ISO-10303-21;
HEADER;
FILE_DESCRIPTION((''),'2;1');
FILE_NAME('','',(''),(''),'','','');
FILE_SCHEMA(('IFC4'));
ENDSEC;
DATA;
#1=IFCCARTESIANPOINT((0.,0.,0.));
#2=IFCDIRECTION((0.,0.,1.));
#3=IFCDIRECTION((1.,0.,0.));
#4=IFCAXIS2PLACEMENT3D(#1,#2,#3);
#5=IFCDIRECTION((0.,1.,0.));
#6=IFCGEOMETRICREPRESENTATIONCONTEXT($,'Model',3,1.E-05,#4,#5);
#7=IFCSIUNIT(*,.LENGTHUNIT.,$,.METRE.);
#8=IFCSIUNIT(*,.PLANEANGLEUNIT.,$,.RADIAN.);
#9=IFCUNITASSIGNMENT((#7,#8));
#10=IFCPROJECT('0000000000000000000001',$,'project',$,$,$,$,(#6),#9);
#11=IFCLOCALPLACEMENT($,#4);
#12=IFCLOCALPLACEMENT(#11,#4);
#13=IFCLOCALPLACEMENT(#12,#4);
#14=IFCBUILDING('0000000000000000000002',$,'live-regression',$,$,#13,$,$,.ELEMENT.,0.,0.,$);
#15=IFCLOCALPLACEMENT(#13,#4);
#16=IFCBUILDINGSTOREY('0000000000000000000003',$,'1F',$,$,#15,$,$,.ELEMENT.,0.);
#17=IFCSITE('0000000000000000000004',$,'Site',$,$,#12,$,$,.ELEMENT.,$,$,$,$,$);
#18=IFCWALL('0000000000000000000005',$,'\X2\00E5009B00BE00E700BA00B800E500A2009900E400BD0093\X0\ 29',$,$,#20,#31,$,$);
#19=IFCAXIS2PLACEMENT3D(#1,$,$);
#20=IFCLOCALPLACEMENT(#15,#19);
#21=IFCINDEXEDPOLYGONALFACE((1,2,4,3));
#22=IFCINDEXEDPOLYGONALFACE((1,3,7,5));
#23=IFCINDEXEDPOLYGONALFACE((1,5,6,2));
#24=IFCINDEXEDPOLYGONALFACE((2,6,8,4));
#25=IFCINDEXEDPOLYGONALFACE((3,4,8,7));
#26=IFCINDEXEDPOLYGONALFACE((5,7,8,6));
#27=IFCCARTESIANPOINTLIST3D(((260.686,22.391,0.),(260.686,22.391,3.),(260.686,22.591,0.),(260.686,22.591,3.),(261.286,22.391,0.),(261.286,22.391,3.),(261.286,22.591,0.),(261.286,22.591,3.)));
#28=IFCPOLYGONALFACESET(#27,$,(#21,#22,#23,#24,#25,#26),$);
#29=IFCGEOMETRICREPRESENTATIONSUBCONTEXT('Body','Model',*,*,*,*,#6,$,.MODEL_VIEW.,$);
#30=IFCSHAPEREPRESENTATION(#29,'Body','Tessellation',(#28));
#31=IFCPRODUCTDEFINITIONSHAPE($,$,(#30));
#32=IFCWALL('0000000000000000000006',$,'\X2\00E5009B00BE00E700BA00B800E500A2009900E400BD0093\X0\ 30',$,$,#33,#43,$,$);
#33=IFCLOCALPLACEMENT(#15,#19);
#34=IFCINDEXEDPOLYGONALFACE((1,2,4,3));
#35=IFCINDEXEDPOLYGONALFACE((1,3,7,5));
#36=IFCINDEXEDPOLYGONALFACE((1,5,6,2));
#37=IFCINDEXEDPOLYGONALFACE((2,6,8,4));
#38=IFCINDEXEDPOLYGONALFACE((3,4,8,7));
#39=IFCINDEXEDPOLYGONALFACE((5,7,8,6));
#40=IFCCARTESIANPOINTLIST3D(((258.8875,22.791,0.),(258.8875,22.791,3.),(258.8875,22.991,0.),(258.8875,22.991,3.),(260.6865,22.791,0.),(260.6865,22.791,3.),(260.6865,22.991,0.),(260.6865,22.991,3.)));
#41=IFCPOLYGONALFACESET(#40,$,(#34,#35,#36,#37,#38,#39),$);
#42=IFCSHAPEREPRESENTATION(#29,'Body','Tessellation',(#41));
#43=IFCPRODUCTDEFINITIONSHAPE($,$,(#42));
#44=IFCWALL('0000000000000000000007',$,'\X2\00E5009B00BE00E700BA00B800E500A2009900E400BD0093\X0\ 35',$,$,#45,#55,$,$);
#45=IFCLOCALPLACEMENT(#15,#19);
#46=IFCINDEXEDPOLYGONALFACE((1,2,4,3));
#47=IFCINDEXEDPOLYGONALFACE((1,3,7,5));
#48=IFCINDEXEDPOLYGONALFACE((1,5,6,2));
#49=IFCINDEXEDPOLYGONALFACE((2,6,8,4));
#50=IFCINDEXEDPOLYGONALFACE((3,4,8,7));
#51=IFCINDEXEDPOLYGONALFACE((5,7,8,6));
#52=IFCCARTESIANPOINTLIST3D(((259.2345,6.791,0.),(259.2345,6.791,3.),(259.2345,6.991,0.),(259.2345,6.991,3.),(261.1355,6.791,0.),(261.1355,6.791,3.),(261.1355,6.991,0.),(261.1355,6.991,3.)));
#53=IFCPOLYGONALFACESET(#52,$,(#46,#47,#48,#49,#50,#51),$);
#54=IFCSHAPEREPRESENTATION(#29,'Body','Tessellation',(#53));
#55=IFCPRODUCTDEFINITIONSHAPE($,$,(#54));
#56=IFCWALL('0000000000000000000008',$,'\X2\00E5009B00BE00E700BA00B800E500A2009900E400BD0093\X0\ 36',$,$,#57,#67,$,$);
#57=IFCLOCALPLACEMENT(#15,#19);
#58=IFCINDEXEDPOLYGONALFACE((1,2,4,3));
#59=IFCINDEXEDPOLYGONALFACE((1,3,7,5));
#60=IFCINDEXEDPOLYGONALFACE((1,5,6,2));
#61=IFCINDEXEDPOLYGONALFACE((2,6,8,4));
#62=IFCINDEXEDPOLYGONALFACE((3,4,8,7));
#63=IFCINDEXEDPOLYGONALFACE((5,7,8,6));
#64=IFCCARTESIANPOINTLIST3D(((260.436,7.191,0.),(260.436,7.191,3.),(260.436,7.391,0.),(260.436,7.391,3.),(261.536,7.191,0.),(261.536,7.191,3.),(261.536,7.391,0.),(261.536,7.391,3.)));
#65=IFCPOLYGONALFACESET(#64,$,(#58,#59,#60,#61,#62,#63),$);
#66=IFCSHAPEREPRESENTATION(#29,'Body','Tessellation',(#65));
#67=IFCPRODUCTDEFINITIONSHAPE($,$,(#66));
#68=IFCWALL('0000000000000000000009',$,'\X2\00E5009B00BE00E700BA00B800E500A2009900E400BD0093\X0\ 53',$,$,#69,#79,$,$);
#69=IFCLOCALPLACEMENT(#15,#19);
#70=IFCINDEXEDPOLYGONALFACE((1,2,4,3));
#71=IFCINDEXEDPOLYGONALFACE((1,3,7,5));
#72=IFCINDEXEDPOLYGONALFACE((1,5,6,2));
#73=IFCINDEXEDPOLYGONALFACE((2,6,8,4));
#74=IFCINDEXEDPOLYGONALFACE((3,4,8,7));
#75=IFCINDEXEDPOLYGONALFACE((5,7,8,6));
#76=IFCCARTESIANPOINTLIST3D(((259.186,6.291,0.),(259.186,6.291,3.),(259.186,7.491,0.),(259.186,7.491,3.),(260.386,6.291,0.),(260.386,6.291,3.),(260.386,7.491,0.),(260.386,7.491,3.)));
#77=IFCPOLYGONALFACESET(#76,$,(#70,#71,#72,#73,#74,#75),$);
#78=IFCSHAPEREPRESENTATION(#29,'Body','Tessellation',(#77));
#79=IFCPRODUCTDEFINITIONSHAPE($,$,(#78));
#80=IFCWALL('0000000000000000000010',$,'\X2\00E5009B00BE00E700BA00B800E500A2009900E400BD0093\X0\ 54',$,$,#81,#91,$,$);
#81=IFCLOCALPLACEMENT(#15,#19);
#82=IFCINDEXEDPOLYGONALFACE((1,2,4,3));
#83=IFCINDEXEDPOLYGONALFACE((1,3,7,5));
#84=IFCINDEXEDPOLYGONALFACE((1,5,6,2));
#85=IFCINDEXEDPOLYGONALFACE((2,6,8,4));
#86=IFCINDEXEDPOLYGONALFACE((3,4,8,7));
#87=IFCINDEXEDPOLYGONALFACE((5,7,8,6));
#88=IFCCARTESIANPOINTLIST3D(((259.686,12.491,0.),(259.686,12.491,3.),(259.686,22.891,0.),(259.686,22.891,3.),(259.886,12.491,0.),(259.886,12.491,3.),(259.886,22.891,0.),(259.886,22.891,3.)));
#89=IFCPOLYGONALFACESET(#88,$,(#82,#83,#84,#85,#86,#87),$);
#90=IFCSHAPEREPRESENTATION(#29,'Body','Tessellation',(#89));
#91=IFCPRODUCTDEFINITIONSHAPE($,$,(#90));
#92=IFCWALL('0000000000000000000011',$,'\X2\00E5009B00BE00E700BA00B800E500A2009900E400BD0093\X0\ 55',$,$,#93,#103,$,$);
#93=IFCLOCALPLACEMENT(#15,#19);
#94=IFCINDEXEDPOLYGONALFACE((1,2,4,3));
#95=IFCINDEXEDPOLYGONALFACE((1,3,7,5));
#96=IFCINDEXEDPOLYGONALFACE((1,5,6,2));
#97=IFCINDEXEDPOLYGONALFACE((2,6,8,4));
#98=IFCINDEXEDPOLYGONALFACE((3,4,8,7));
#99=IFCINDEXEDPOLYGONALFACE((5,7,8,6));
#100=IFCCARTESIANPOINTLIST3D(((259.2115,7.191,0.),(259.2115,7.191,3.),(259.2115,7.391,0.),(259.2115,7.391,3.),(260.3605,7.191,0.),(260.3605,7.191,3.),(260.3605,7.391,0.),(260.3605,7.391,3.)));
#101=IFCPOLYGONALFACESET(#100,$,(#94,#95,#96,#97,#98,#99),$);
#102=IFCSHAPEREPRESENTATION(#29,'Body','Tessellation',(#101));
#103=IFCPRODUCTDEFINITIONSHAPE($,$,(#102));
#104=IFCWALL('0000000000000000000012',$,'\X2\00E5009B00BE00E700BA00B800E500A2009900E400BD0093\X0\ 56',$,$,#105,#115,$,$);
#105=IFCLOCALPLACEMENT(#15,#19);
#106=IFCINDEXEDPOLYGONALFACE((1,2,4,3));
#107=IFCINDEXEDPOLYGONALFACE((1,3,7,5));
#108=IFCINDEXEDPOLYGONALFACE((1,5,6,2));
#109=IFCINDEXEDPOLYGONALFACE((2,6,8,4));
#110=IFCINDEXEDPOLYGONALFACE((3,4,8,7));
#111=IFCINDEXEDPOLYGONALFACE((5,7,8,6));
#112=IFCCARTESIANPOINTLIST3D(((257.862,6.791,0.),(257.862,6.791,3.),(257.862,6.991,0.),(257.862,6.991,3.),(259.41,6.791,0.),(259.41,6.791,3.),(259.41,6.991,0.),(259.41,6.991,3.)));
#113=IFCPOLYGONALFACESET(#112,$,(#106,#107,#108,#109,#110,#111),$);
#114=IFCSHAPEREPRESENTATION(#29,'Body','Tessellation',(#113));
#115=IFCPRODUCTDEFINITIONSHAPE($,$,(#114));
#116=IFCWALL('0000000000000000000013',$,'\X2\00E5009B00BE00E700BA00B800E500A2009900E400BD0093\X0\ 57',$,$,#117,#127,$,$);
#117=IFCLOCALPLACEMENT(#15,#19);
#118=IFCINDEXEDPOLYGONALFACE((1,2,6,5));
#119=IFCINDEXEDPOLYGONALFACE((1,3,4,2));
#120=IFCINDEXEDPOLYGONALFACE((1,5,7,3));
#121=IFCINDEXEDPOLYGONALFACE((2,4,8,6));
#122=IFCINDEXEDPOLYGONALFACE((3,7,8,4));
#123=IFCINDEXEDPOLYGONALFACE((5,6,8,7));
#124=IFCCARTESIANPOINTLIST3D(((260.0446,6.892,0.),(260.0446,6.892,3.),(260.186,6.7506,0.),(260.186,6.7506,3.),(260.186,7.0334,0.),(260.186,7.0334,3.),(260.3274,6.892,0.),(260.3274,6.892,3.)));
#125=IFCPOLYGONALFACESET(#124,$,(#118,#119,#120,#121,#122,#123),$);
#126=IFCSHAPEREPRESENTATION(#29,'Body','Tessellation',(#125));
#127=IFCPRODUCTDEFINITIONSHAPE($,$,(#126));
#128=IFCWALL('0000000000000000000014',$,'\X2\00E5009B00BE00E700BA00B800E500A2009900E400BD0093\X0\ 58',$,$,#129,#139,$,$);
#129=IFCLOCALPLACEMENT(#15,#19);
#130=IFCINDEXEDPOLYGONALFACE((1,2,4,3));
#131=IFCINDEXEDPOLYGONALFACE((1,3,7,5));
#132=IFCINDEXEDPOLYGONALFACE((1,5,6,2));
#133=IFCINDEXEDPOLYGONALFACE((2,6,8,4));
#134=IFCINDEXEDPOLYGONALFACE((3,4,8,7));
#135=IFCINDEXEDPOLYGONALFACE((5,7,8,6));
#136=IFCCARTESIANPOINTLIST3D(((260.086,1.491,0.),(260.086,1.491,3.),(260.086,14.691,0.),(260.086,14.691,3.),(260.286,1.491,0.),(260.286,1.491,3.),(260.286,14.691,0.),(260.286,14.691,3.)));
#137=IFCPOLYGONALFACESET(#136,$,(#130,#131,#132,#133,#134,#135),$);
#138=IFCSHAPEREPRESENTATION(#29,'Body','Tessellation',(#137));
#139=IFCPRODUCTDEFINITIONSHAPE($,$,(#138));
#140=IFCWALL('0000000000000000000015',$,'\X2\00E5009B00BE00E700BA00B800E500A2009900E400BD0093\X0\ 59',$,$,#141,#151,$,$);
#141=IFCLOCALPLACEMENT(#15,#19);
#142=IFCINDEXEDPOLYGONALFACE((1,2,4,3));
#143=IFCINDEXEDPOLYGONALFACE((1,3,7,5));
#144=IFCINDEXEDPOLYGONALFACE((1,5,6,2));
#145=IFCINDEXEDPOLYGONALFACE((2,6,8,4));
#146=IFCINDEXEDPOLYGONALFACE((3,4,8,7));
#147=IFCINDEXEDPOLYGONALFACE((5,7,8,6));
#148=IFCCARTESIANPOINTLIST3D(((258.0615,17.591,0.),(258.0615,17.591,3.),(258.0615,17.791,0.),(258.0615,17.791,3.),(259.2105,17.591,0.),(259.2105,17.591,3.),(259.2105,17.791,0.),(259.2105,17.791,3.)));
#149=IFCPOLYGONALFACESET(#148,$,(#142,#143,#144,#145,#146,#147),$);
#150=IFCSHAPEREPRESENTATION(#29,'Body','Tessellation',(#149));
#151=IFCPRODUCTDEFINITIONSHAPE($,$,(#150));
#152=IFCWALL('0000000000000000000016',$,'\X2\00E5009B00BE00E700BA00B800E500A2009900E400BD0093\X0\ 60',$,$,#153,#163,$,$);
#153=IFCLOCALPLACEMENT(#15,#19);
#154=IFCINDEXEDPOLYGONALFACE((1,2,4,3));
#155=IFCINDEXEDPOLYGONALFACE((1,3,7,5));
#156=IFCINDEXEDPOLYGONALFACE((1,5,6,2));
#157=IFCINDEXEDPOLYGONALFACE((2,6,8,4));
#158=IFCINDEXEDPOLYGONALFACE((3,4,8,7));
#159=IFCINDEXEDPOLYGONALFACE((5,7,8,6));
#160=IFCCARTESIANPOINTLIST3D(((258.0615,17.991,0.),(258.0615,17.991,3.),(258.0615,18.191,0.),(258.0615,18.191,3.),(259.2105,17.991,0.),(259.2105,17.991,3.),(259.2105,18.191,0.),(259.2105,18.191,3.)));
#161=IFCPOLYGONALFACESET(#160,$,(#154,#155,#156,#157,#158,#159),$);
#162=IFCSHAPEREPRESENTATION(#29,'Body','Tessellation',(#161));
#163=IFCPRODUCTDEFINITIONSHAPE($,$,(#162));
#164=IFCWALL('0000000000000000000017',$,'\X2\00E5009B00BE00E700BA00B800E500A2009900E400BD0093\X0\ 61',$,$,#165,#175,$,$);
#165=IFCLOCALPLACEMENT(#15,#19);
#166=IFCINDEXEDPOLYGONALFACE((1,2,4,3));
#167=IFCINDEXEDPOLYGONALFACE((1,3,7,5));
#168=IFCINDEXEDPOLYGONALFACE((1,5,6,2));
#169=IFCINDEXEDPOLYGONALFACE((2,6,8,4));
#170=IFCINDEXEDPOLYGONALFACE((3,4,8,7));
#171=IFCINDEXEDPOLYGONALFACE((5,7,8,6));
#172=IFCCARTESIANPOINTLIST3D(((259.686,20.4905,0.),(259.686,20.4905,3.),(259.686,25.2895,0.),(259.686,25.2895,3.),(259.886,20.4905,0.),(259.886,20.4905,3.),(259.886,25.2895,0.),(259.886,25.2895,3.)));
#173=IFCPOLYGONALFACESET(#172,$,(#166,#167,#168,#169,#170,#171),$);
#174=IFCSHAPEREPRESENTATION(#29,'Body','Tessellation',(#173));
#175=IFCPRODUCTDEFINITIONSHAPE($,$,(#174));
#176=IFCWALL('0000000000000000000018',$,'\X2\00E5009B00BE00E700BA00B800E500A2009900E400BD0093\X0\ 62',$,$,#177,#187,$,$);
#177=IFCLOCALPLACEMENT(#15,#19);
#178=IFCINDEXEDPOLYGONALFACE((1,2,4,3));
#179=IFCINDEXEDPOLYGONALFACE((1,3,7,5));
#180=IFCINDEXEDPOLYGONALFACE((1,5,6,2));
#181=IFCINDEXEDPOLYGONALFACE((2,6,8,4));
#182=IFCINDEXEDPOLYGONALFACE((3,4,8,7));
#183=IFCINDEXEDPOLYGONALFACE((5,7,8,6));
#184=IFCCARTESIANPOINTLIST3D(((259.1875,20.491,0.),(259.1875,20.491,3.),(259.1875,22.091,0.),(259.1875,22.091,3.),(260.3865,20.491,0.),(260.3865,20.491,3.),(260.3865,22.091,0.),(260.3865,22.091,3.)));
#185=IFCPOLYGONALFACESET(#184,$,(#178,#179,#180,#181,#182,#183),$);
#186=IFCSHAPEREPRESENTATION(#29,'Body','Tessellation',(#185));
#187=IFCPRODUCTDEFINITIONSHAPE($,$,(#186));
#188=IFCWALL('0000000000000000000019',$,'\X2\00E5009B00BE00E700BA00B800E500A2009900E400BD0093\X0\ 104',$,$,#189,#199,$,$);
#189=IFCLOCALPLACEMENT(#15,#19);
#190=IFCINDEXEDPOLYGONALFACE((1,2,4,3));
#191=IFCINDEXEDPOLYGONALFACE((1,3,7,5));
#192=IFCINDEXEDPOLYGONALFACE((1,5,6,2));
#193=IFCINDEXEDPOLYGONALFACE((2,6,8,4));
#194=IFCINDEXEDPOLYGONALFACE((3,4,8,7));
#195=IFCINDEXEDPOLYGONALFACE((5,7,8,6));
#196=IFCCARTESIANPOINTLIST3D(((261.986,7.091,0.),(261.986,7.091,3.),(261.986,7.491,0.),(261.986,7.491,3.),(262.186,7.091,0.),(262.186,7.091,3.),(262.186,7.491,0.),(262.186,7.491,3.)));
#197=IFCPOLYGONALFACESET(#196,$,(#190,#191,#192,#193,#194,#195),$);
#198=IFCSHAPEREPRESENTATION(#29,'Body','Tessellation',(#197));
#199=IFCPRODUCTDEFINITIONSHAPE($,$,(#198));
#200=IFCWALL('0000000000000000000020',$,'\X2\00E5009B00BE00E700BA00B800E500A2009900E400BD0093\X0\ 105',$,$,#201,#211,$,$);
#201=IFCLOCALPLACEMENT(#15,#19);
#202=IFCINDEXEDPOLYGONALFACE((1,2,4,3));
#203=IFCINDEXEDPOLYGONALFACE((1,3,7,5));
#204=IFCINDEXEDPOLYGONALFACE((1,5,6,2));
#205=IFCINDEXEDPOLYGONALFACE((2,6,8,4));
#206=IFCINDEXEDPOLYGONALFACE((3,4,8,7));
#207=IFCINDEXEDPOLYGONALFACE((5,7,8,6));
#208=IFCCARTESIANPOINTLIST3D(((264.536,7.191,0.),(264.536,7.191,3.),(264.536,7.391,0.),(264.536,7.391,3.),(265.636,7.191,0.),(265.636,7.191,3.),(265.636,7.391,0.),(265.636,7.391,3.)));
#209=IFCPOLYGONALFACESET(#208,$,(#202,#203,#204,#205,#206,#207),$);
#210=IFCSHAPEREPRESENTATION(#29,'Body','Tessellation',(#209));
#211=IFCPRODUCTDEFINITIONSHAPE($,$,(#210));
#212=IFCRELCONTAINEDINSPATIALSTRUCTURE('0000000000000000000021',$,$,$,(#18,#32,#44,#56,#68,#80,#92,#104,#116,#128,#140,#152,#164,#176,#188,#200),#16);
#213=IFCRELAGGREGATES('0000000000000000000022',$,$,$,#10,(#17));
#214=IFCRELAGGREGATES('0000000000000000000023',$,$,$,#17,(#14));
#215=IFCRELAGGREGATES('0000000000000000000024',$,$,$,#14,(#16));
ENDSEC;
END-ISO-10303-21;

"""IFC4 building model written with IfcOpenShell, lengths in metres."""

from ifc_helpers import new_model, si_unit, direction, frame, frame_2d, origin_with_axes, place, context, subcontext, project, spatial, rectangle, extrude, element, save


model = new_model("IFC4")

# Units and contexts
model_context = context("Model", 3, precision=1e-05, world=origin_with_axes(), true_north=direction((0.0, 1.0, 0.0)))
body_context = subcontext(model_context, "Body", "Model", "MODEL_VIEW")
ifc_project = project(units=[si_unit("LENGTHUNIT", "METRE"), si_unit("PLANEANGLEUNIT", "RADIAN")], contexts=[model_context])

# Site, building, storey
placement = place(None, origin_with_axes())
site_placement = place(placement, origin_with_axes())
site = spatial("IfcSite", under=ifc_project, at=site_placement, Name="Site", CompositionType="ELEMENT")
building_placement = place(site_placement, origin_with_axes())
building = spatial("IfcBuilding", under=site, at=building_placement, Name="live-regression", CompositionType="ELEMENT", ElevationOfRefHeight=0.0, ElevationOfTerrain=0.0)
storey_placement = place(building_placement, origin_with_axes())
storey = spatial("IfcBuildingStorey", under=building, at=storey_placement, Name="1F", CompositionType="ELEMENT", Elevation=0.0)

# Walls
wall_1_placement = place(storey_placement, frame((260.986, 22.491, 0.0), z_axis=(0.0, 0.0, 1.0), x_axis=(1.0, 0.0, 0.0)))
element("IfcWall", 1, at=wall_1_placement, inside=storey, Name="å\u009b¾çº¸å¢\u0099ä½\u0093 29", context=body_context, shape_type="SweptSolid", body=[
    extrude(rectangle(XDim=0.6, YDim=0.2, at=frame_2d((0.0, 0.0), x_axis=(1.0, 0.0, 0.0))), frame((0.0, 0.0, 0.0), z_axis=(0.0, 0.0, 1.0)), (0.0, 0.0, 1.0), 3.0),
])
wall_2_placement = place(storey_placement, frame((259.787, 22.891, 0.0), z_axis=(0.0, 0.0, 1.0), x_axis=(1.0, 0.0, 0.0)))
element("IfcWall", 2, at=wall_2_placement, inside=storey, Name="å\u009b¾çº¸å¢\u0099ä½\u0093 30", context=body_context, shape_type="SweptSolid", body=[
    extrude(rectangle(XDim=1.799, YDim=0.2, at=frame_2d((0.0, 0.0), x_axis=(1.0, 0.0, 0.0))), frame((0.0, 0.0, 0.0), z_axis=(0.0, 0.0, 1.0)), (0.0, 0.0, 1.0), 3.0),
])
wall_3_placement = place(storey_placement, frame((260.185, 6.891, 0.0), z_axis=(0.0, 0.0, 1.0), x_axis=(1.0, 0.0, 0.0)))
element("IfcWall", 3, at=wall_3_placement, inside=storey, Name="å\u009b¾çº¸å¢\u0099ä½\u0093 35", context=body_context, shape_type="SweptSolid", body=[
    extrude(rectangle(XDim=1.901, YDim=0.2, at=frame_2d((0.0, 0.0), x_axis=(1.0, 0.0, 0.0))), frame((0.0, 0.0, 0.0), z_axis=(0.0, 0.0, 1.0)), (0.0, 0.0, 1.0), 3.0),
])
wall_4_placement = place(storey_placement, frame((260.986, 7.291, 0.0), z_axis=(0.0, 0.0, 1.0), x_axis=(1.0, 0.0, 0.0)))
element("IfcWall", 4, at=wall_4_placement, inside=storey, Name="å\u009b¾çº¸å¢\u0099ä½\u0093 36", context=body_context, shape_type="SweptSolid", body=[
    extrude(rectangle(XDim=1.1, YDim=0.2, at=frame_2d((0.0, 0.0), x_axis=(1.0, 0.0, 0.0))), frame((0.0, 0.0, 0.0), z_axis=(0.0, 0.0, 1.0)), (0.0, 0.0, 1.0), 3.0),
])
wall_5_placement = place(storey_placement, frame((259.786, 6.891, 0.0), z_axis=(0.0, 0.0, 1.0), x_axis=(1.0, 0.0, 0.0)))
element("IfcWall", 5, at=wall_5_placement, inside=storey, Name="å\u009b¾çº¸å¢\u0099ä½\u0093 53", context=body_context, shape_type="SweptSolid", body=[
    extrude(rectangle(XDim=1.2, YDim=1.2, at=frame_2d((0.0, 0.0), x_axis=(1.0, 0.0, 0.0))), frame((0.0, 0.0, 0.0), z_axis=(0.0, 0.0, 1.0)), (0.0, 0.0, 1.0), 3.0),
])
wall_6_placement = place(storey_placement, frame((259.786, 17.691, 0.0), z_axis=(0.0, 0.0, 1.0), x_axis=(0.0, -1.0, 0.0)))
element("IfcWall", 6, at=wall_6_placement, inside=storey, Name="å\u009b¾çº¸å¢\u0099ä½\u0093 54", context=body_context, shape_type="SweptSolid", body=[
    extrude(rectangle(XDim=10.4, YDim=0.2, at=frame_2d((0.0, 0.0), x_axis=(1.0, 0.0, 0.0))), frame((0.0, 0.0, 0.0), z_axis=(0.0, 0.0, 1.0)), (0.0, 0.0, 1.0), 3.0),
])
wall_7_placement = place(storey_placement, frame((259.786, 7.291, 0.0), z_axis=(0.0, 0.0, 1.0), x_axis=(-1.0, 0.0, 0.0)))
element("IfcWall", 7, at=wall_7_placement, inside=storey, Name="å\u009b¾çº¸å¢\u0099ä½\u0093 55", context=body_context, shape_type="SweptSolid", body=[
    extrude(rectangle(XDim=1.149, YDim=0.2, at=frame_2d((0.0, 0.0), x_axis=(1.0, 0.0, 0.0))), frame((0.0, 0.0, 0.0), z_axis=(0.0, 0.0, 1.0)), (0.0, 0.0, 1.0), 3.0),
])
wall_8_placement = place(storey_placement, frame((258.636, 6.891, 0.0), z_axis=(0.0, 0.0, 1.0), x_axis=(1.0, 0.0, 0.0)))
element("IfcWall", 8, at=wall_8_placement, inside=storey, Name="å\u009b¾çº¸å¢\u0099ä½\u0093 56", context=body_context, shape_type="SweptSolid", body=[
    extrude(rectangle(XDim=1.548, YDim=0.2, at=frame_2d((0.0, 0.0), x_axis=(1.0, 0.0, 0.0))), frame((0.0, 0.0, 0.0), z_axis=(0.0, 0.0, 1.0)), (0.0, 0.0, 1.0), 3.0),
])
wall_9_placement = place(storey_placement, frame((260.186, 6.892, 0.0), z_axis=(0.0, 0.0, 1.0), x_axis=(-0.707107, -0.707107, 0.0)))
element("IfcWall", 9, at=wall_9_placement, inside=storey, Name="å\u009b¾çº¸å¢\u0099ä½\u0093 57", context=body_context, shape_type="SweptSolid", body=[
    extrude(rectangle(XDim=0.2, YDim=0.2, at=frame_2d((0.0, 0.0), x_axis=(1.0, 0.0, 0.0))), frame((0.0, 0.0, 0.0), z_axis=(0.0, 0.0, 1.0)), (0.0, 0.0, 1.0), 3.0),
])
wall_10_placement = place(storey_placement, frame((260.186, 8.091, 0.0), z_axis=(0.0, 0.0, 1.0), x_axis=(0.0, 1.0, 0.0)))
element("IfcWall", 10, at=wall_10_placement, inside=storey, Name="å\u009b¾çº¸å¢\u0099ä½\u0093 58", context=body_context, shape_type="SweptSolid", body=[
    extrude(rectangle(XDim=13.2, YDim=0.2, at=frame_2d((0.0, 0.0), x_axis=(1.0, 0.0, 0.0))), frame((0.0, 0.0, 0.0), z_axis=(0.0, 0.0, 1.0)), (0.0, 0.0, 1.0), 3.0),
])
for number, where, z_axis, x_axis, name in (
    (11, (258.636, 17.691, 0.0), (0.0, 0.0, 1.0), (1.0, 0.0, 0.0), "å\u009b¾çº¸å¢\u0099ä½\u0093 59"),
    (12, (258.636, 18.091, 0.0), (0.0, 0.0, 1.0), (1.0, 0.0, 0.0), "å\u009b¾çº¸å¢\u0099ä½\u0093 60"),
):
    element("IfcWall", number, at=place(storey_placement, frame(where, z_axis=z_axis, x_axis=x_axis)), inside=storey, Name=name, context=body_context, shape_type="SweptSolid", body=[
        extrude(rectangle(XDim=1.149, YDim=0.2, at=frame_2d((0.0, 0.0), x_axis=(1.0, 0.0, 0.0))), frame((0.0, 0.0, 0.0), z_axis=(0.0, 0.0, 1.0)), (0.0, 0.0, 1.0), 3.0),
    ])
wall_11_placement = place(storey_placement, frame((259.786, 22.89, 0.0), z_axis=(0.0, 0.0, 1.0), x_axis=(0.0, -1.0, 0.0)))
element("IfcWall", 13, at=wall_11_placement, inside=storey, Name="å\u009b¾çº¸å¢\u0099ä½\u0093 61", context=body_context, shape_type="SweptSolid", body=[
    extrude(rectangle(XDim=4.799, YDim=0.2, at=frame_2d((0.0, 0.0), x_axis=(1.0, 0.0, 0.0))), frame((0.0, 0.0, 0.0), z_axis=(0.0, 0.0, 1.0)), (0.0, 0.0, 1.0), 3.0),
])
wall_12_placement = place(storey_placement, frame((259.787, 21.291, 0.0), z_axis=(0.0, 0.0, 1.0), x_axis=(1.0, 0.0, 0.0)))
element("IfcWall", 14, at=wall_12_placement, inside=storey, Name="å\u009b¾çº¸å¢\u0099ä½\u0093 62", context=body_context, shape_type="SweptSolid", body=[
    extrude(rectangle(XDim=1.199, YDim=1.6, at=frame_2d((0.0, 0.0), x_axis=(1.0, 0.0, 0.0))), frame((0.0, 0.0, 0.0), z_axis=(0.0, 0.0, 1.0)), (0.0, 0.0, 1.0), 3.0),
])
wall_13_placement = place(storey_placement, frame((262.086, 7.291, 0.0), z_axis=(0.0, 0.0, 1.0), x_axis=(0.0, -1.0, 0.0)))
element("IfcWall", 15, at=wall_13_placement, inside=storey, Name="å\u009b¾çº¸å¢\u0099ä½\u0093 104", context=body_context, shape_type="SweptSolid", body=[
    extrude(rectangle(XDim=0.4, YDim=0.2, at=frame_2d((0.0, 0.0), x_axis=(1.0, 0.0, 0.0))), frame((0.0, 0.0, 0.0), z_axis=(0.0, 0.0, 1.0)), (0.0, 0.0, 1.0), 3.0),
])
wall_14_placement = place(storey_placement, frame((265.086, 7.291, 0.0), z_axis=(0.0, 0.0, 1.0), x_axis=(1.0, 0.0, 0.0)))
element("IfcWall", 16, at=wall_14_placement, inside=storey, Name="å\u009b¾çº¸å¢\u0099ä½\u0093 105", context=body_context, shape_type="SweptSolid", body=[
    extrude(rectangle(XDim=1.1, YDim=0.2, at=frame_2d((0.0, 0.0), x_axis=(1.0, 0.0, 0.0))), frame((0.0, 0.0, 0.0), z_axis=(0.0, 0.0, 1.0)), (0.0, 0.0, 1.0), 3.0),
])

save(model, "model.ifc")
